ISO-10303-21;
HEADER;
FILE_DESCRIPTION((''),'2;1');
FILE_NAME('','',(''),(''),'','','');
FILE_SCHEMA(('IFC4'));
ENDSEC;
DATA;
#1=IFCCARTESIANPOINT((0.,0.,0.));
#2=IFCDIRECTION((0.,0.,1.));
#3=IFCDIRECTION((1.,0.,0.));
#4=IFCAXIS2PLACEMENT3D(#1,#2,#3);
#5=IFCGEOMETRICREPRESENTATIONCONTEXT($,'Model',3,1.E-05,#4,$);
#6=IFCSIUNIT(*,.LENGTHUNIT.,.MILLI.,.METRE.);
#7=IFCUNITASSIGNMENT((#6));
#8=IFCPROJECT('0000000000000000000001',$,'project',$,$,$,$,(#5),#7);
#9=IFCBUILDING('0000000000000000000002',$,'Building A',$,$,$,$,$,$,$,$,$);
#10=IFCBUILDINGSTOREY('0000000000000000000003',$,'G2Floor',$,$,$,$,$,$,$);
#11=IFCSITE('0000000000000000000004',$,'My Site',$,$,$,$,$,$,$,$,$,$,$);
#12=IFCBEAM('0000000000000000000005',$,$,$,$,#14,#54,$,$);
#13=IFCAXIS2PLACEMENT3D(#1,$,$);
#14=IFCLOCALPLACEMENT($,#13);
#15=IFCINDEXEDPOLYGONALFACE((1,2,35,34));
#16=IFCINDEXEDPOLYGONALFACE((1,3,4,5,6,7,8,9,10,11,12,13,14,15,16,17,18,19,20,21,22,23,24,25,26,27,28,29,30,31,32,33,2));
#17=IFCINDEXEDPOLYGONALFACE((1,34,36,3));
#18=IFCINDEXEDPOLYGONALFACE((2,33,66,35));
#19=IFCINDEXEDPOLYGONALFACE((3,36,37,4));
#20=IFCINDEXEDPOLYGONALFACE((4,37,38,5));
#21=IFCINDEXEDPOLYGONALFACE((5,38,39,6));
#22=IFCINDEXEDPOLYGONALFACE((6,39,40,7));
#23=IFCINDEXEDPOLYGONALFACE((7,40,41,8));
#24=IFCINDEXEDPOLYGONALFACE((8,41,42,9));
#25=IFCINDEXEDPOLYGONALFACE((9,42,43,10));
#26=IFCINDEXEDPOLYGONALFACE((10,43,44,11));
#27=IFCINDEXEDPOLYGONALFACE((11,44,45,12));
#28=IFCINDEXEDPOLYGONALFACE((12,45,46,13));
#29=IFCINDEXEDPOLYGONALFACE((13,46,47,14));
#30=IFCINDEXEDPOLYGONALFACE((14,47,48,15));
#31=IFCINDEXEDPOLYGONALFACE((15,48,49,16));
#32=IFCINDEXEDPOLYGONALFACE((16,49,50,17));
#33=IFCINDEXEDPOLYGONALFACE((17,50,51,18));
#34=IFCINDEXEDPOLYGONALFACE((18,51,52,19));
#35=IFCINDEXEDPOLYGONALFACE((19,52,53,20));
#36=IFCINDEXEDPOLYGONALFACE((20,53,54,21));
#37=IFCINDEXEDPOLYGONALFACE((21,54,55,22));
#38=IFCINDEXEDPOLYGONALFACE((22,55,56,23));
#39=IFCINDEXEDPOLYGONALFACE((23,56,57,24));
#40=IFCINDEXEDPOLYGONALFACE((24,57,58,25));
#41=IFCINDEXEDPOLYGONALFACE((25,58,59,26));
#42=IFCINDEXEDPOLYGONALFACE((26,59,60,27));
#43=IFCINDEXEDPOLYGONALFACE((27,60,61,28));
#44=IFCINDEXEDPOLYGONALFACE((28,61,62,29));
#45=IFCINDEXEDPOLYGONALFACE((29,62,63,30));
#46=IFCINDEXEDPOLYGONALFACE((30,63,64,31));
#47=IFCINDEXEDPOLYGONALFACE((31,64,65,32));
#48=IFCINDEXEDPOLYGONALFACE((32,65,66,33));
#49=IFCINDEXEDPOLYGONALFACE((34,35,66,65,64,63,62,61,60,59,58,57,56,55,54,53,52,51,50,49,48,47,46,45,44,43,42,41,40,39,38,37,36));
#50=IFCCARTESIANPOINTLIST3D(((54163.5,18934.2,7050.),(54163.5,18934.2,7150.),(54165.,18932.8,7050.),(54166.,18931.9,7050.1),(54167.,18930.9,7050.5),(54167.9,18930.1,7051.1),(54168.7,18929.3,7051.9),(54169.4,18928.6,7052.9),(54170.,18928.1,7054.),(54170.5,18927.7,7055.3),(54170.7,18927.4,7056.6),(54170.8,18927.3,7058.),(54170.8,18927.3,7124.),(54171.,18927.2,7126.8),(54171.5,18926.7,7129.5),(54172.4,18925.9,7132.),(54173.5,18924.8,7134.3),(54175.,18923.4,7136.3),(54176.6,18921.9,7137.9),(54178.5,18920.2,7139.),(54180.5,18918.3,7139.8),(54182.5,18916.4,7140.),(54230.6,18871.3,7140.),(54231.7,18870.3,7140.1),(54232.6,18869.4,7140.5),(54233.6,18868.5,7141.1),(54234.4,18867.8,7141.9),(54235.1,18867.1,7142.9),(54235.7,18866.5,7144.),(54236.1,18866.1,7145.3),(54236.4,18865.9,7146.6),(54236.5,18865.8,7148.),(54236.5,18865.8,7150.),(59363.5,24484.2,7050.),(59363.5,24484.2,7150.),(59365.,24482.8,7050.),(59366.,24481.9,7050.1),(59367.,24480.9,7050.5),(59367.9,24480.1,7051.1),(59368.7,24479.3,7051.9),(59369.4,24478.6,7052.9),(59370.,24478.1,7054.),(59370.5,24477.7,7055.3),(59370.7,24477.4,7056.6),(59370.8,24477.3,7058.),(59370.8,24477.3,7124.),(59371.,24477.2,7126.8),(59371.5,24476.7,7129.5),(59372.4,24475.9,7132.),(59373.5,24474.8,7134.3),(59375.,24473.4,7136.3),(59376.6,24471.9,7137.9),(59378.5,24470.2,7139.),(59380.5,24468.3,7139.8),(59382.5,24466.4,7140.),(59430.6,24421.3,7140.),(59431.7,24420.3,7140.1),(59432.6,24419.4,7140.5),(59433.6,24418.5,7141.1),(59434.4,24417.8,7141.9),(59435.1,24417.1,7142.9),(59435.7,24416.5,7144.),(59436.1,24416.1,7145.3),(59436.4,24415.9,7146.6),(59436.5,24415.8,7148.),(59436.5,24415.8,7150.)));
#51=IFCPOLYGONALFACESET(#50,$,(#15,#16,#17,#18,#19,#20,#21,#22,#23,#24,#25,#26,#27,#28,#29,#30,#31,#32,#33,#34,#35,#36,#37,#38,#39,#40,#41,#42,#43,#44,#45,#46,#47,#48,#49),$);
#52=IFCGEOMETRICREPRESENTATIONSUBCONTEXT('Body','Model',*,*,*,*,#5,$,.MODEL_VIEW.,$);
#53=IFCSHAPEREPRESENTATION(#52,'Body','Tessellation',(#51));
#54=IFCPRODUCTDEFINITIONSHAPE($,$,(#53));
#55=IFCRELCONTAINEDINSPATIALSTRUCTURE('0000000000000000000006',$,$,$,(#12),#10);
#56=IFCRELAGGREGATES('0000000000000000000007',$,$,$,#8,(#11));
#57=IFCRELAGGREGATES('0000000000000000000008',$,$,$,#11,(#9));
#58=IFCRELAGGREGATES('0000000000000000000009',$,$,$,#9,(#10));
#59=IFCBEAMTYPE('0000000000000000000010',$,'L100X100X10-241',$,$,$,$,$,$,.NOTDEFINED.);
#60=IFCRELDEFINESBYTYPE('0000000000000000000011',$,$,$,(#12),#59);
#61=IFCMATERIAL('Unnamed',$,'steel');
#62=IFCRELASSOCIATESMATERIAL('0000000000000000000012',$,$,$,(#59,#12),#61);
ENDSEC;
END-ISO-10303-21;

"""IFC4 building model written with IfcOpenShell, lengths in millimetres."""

from ifc_helpers import new_model, si_unit, frame, origin_with_axes, place, context, subcontext, project, spatial, polyline, outline, extrude, material, material_profile, profile_set, profile_usage, type_object, element, save


model = new_model("IFC4")

# Units and contexts
model_context = context("Model", 3, precision=1e-05, world=origin_with_axes())
body_context = subcontext(model_context, "Body", "Model", "MODEL_VIEW")
ifc_project = project(units=[si_unit("LENGTHUNIT", "METRE", prefix="MILLI")], contexts=[model_context])

# Site, building, storey
site = spatial("IfcSite", under=ifc_project, Name="My Site")
building = spatial("IfcBuilding", under=site, Name="Building A")
storey = spatial("IfcBuildingStorey", under=building, Name="G2Floor")

# Beam
ifc_material_1 = material(Name="Unnamed", Category="steel")
ifc_material_profile_1 = material_profile(ifc_material_1, outline(polyline([(-50.0, -50.0), (50.0, -50.0), (50.0, -50.0), (50.0, -48.0), (50.0, -48.0), (49.9, -46.6), (49.9, -46.6), (49.5, -45.3), (49.5, -45.3), (48.9, -44.0), (48.9, -44.0), (48.1, -42.9), (48.1, -42.9), (47.1, -41.9), (47.1, -41.9), (46.0, -41.1), (46.0, -41.1), (44.7, -40.5), (44.7, -40.5), (43.4, -40.1), (43.4, -40.1), (42.0, -40.0), (42.0, -40.0), (-24.0, -40.0), (-24.0, -40.0), (-26.8, -39.8), (-26.8, -39.8), (-29.5, -39.0), (-29.5, -39.0), (-32.0, -37.9), (-32.0, -37.9), (-34.3, -36.3), (-34.3, -36.3), (-36.3, -34.3), (-36.3, -34.3), (-37.9, -32.0), (-37.9, -32.0), (-39.0, -29.5), (-39.0, -29.5), (-39.8, -26.8), (-39.8, -26.8), (-40.0, -24.0), (-40.0, -24.0), (-40.0, 42.0), (-40.0, 42.0), (-40.1, 43.4), (-40.1, 43.4), (-40.5, 44.7), (-40.5, 44.7), (-41.1, 46.0), (-41.1, 46.0), (-41.9, 47.1), (-41.9, 47.1), (-42.9, 48.1), (-42.9, 48.1), (-44.0, 48.9), (-44.0, 48.9), (-45.3, 49.5), (-45.3, 49.5), (-46.6, 49.9), (-46.6, 49.9), (-48.0, 50.0), (-48.0, 50.0), (-50.0, 50.0), (-50.0, 50.0), (-50.0, -50.0)])))
ifc_profile_set_1 = profile_set([ifc_material_profile_1], Name="L100X100X10-241")
ifc_profile_usage_1 = profile_usage(ifc_profile_set_1)
beam_type_1 = type_object("IfcBeamType", Name="L100X100X10-241", PredefinedType="NOTDEFINED", material=ifc_profile_set_1)
beam_1_placement = place(None, frame((54200.0, 18900.0, 7100.0), z_axis=(0.683722, 0.729742, 0.0), x_axis=(0.729742, -0.683722, 0.0)))
element("IfcBeam", 1, at=beam_1_placement, inside=storey, type_object=beam_type_1, material=ifc_profile_usage_1, context=body_context, shape_type="SweptSolid", body=[
    extrude(outline(polyline([(-50.0, -50.0), (50.0, -50.0), (50.0, -50.0), (50.0, -48.0), (50.0, -48.0), (49.9, -46.6), (49.9, -46.6), (49.5, -45.3), (49.5, -45.3), (48.9, -44.0), (48.9, -44.0), (48.1, -42.9), (48.1, -42.9), (47.1, -41.9), (47.1, -41.9), (46.0, -41.1), (46.0, -41.1), (44.7, -40.5), (44.7, -40.5), (43.4, -40.1), (43.4, -40.1), (42.0, -40.0), (42.0, -40.0), (-24.0, -40.0), (-24.0, -40.0), (-26.8, -39.8), (-26.8, -39.8), (-29.5, -39.0), (-29.5, -39.0), (-32.0, -37.9), (-32.0, -37.9), (-34.3, -36.3), (-34.3, -36.3), (-36.3, -34.3), (-36.3, -34.3), (-37.9, -32.0), (-37.9, -32.0), (-39.0, -29.5), (-39.0, -29.5), (-39.8, -26.8), (-39.8, -26.8), (-40.0, -24.0), (-40.0, -24.0), (-40.0, 42.0), (-40.0, 42.0), (-40.1, 43.4), (-40.1, 43.4), (-40.5, 44.7), (-40.5, 44.7), (-41.1, 46.0), (-41.1, 46.0), (-41.9, 47.1), (-41.9, 47.1), (-42.9, 48.1), (-42.9, 48.1), (-44.0, 48.9), (-44.0, 48.9), (-45.3, 49.5), (-45.3, 49.5), (-46.6, 49.9), (-46.6, 49.9), (-48.0, 50.0), (-48.0, 50.0), (-50.0, 50.0), (-50.0, 50.0), (-50.0, -50.0)])), origin_with_axes(), (0.0, 0.0, 1.0), 7605.4),
])

save(model, "model.ifc")
